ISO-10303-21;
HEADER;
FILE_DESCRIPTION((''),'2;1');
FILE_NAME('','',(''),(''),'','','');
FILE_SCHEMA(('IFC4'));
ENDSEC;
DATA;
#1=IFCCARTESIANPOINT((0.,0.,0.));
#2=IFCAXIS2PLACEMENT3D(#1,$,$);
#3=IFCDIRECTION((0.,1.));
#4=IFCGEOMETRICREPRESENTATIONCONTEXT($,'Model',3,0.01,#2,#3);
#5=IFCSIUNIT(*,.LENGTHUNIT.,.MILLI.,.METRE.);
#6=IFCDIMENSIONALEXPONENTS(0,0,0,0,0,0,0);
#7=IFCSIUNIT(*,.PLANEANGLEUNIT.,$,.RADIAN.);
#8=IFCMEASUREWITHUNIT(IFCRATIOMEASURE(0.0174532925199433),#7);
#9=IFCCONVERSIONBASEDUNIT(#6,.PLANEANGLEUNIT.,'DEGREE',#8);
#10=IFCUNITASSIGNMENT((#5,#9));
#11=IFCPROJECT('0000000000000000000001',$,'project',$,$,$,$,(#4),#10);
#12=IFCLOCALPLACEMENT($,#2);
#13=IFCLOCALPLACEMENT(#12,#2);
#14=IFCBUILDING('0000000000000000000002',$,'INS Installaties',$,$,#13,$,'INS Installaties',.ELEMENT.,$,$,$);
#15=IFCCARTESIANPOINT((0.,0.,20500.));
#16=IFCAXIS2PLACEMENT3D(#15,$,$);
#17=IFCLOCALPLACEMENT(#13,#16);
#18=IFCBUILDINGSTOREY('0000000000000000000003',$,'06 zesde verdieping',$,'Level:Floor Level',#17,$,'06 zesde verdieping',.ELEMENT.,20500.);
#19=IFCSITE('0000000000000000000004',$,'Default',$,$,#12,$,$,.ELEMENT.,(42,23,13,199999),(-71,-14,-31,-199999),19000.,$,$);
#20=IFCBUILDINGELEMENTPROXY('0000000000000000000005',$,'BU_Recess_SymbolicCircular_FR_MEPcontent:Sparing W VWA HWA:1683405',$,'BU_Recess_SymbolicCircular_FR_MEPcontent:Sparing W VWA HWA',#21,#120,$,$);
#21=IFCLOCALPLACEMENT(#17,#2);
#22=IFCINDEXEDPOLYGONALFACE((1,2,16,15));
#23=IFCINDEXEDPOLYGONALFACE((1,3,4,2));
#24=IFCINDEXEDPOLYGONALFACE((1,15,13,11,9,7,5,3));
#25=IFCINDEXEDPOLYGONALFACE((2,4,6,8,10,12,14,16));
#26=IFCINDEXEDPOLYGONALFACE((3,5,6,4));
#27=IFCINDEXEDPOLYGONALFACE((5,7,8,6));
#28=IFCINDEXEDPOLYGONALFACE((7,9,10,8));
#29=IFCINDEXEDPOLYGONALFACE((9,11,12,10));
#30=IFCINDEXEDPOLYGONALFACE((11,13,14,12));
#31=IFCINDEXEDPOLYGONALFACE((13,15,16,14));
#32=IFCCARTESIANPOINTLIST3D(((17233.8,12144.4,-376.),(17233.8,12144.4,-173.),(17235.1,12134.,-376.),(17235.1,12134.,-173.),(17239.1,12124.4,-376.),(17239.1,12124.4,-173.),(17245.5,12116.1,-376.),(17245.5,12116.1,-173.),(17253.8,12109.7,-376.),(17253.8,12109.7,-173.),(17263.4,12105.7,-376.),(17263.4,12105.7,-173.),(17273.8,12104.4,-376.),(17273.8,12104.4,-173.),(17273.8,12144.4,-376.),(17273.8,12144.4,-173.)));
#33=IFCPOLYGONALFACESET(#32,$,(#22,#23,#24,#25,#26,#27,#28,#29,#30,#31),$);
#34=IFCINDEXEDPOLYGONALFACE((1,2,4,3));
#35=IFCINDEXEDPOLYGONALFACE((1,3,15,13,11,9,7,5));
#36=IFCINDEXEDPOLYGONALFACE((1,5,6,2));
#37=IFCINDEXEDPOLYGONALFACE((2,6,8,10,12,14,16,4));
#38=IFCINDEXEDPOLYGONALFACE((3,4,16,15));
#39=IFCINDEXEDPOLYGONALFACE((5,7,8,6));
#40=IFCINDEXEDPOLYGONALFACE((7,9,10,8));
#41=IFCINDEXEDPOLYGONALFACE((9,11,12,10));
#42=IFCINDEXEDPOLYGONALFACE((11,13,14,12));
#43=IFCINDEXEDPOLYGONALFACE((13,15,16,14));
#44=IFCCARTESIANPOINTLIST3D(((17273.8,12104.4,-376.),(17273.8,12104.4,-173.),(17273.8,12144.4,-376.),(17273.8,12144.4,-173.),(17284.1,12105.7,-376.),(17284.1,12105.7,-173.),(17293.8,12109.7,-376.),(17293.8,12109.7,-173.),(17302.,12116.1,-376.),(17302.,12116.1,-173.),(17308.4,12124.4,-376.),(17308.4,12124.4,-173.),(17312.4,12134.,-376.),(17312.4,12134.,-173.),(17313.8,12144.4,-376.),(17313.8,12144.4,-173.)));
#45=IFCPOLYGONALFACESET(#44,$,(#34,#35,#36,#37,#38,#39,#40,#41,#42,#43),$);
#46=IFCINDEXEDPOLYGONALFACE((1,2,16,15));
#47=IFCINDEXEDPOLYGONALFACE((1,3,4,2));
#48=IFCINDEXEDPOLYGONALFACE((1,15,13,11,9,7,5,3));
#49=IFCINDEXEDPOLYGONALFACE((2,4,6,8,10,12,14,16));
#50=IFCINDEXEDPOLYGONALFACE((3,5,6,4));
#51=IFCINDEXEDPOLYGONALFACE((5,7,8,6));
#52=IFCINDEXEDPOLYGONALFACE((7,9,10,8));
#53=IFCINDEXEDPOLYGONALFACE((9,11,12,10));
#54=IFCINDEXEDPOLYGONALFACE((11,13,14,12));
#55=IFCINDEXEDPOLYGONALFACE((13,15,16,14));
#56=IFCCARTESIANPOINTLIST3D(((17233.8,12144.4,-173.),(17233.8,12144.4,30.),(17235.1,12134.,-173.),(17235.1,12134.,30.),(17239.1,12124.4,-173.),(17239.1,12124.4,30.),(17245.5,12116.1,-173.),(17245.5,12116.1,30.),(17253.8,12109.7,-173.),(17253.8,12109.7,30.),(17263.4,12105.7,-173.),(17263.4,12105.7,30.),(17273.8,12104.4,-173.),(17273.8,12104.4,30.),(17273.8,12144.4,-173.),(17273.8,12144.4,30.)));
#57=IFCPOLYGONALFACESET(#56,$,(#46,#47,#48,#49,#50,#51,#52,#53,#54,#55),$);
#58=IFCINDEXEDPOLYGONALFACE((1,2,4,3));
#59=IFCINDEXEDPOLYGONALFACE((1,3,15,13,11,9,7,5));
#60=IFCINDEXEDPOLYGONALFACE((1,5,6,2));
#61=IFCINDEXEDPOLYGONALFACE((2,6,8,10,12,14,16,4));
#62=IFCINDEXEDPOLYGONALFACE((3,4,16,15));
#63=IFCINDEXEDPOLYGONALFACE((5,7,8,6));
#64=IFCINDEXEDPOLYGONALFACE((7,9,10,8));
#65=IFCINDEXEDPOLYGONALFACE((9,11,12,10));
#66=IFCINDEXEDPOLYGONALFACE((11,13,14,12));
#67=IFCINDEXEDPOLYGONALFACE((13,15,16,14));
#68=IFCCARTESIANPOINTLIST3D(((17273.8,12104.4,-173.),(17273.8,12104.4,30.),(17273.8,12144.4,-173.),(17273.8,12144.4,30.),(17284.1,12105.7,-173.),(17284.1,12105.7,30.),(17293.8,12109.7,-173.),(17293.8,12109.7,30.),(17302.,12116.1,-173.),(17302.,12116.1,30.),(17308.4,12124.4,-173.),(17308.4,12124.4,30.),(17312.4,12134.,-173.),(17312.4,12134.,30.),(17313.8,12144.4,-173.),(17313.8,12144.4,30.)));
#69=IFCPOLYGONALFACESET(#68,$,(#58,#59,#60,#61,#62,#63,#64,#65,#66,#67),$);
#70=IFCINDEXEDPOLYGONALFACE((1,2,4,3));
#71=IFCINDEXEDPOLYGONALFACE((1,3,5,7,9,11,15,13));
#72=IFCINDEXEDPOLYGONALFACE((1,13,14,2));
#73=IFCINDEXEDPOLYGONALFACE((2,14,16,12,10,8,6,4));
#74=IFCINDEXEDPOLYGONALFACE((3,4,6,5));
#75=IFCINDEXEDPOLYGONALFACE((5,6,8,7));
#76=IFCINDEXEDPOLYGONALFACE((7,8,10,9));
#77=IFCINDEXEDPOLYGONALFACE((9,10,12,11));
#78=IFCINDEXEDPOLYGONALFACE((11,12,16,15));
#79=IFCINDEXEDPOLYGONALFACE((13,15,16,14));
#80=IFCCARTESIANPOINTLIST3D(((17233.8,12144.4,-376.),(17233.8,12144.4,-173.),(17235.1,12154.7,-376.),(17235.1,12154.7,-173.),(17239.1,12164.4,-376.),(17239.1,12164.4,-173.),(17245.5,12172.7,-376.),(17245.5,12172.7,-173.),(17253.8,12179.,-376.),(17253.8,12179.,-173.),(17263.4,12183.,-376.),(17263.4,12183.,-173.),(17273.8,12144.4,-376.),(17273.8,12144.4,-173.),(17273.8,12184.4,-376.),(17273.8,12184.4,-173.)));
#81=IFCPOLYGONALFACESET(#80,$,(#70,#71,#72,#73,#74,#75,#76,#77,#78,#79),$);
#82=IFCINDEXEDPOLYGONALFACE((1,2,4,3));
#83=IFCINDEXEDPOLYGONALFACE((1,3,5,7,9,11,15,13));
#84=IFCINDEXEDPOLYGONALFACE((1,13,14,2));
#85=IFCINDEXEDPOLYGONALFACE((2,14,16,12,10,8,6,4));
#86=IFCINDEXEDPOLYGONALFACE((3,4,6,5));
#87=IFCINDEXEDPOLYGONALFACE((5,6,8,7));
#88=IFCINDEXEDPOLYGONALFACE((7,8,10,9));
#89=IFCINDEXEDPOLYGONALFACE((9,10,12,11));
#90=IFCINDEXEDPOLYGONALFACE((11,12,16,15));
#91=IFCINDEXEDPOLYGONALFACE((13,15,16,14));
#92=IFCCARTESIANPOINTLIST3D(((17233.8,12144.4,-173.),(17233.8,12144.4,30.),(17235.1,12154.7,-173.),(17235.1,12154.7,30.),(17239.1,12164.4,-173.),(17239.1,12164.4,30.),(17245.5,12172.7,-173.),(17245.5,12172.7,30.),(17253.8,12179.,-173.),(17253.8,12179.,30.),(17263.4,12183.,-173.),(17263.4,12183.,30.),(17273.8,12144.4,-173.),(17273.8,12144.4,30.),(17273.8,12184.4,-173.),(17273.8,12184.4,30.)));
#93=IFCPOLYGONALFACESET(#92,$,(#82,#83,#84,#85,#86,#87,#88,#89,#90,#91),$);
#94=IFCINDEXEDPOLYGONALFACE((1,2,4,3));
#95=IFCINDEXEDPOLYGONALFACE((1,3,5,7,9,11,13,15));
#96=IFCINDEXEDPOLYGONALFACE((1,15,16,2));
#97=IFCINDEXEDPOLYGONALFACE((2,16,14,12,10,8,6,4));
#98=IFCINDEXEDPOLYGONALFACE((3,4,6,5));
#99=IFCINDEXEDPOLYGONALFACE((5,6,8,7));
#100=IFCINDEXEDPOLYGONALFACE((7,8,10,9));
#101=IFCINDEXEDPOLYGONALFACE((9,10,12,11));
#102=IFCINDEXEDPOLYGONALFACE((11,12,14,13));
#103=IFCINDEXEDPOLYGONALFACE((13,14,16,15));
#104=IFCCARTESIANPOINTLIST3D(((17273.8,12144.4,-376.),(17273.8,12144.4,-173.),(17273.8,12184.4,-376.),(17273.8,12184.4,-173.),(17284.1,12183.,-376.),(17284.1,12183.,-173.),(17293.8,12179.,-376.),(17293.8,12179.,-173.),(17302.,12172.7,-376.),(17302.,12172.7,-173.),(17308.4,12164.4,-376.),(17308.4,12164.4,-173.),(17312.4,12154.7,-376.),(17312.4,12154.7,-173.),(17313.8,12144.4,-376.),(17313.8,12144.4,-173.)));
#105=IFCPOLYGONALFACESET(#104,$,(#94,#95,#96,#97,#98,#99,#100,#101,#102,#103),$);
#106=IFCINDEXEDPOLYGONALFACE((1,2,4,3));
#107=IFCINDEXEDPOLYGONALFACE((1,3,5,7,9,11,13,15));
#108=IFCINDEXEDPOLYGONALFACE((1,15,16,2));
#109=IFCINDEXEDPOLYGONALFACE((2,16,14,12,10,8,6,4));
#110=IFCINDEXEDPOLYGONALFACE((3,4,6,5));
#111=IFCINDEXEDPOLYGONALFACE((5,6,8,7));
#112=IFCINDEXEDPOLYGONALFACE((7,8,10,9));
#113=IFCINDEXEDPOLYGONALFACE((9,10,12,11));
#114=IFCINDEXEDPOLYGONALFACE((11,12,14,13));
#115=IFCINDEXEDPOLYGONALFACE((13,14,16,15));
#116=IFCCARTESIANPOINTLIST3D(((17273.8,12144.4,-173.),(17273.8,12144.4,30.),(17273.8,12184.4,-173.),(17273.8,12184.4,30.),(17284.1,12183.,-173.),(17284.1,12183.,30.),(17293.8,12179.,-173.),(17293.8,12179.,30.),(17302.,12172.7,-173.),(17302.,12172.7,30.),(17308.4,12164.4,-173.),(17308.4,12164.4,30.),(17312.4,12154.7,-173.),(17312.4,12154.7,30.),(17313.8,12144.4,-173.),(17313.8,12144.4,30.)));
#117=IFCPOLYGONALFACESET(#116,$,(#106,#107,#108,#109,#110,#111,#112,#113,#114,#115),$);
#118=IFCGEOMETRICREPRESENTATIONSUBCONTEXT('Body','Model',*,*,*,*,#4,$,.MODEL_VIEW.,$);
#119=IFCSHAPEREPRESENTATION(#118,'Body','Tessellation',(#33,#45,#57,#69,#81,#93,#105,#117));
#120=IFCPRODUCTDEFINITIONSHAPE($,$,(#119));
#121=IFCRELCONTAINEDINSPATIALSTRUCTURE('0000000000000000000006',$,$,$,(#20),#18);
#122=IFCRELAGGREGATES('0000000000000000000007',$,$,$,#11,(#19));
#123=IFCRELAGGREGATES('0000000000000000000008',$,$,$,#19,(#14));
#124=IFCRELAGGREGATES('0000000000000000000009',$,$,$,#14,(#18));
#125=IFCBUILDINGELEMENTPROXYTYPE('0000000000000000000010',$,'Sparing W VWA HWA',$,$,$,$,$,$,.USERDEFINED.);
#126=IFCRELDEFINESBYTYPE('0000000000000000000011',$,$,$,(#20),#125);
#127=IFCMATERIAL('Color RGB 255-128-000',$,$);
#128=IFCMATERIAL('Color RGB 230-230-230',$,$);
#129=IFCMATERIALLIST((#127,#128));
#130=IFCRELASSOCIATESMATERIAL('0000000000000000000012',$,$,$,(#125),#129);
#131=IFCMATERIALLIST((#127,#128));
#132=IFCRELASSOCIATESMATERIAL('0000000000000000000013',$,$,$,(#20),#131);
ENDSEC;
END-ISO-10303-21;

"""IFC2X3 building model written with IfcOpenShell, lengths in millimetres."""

from ifc_helpers import new_model, entity, si_unit, converted_unit, direction, frame, frame_2d, origin, place, context, subcontext, project, spatial, polyline, circle_curve, parameter, trimmed, segment, composite_curve, outline, extrude, source, transform, mapped, material, material_list, type_object, type_shapes, element, save


model = new_model("IFC2X3")

# Units and contexts
model_context = context("Model", 3, precision=0.01, world=origin(), true_north=direction((0.0, 1.0)))
body_context = subcontext(model_context, "Body", "Model", "MODEL_VIEW")
ifc_project = project(units=[si_unit("LENGTHUNIT", "METRE", prefix="MILLI"), converted_unit("PLANEANGLEUNIT", "DEGREE", entity("IfcRatioMeasure", 0.0174532925199433), si_unit("PLANEANGLEUNIT", "RADIAN"), dimensions=[0, 0, 0, 0, 0, 0, 0])], contexts=[model_context])

# Site, building, storey
site_placement = place(None, origin())
site = spatial("IfcSite", under=ifc_project, at=site_placement, Name="Default", CompositionType="ELEMENT", RefLatitude=(42, 23, 13, 199999), RefLongitude=(-71, -14, -31, -199999), RefElevation=19000.0)
building_placement = place(site_placement, origin())
building = spatial("IfcBuilding", under=site, at=building_placement, Name="INS Installaties", LongName="INS Installaties", CompositionType="ELEMENT")
storey_placement = place(building_placement, frame((0.0, 0.0, 20500.0)))
storey = spatial("IfcBuildingStorey", under=building, at=storey_placement, Name="06 zesde verdieping", ObjectType="Level:Floor Level", LongName="06 zesde verdieping", CompositionType="ELEMENT", Elevation=20500.0)

# Building element proxy
ifc_material_1 = material(Name="Color RGB 255-128-000")
ifc_material_2 = material(Name="Color RGB 230-230-230")
ifc_material_list_1 = material_list([ifc_material_1, ifc_material_2])
building_element_proxy_type_1 = type_object("IfcBuildingElementProxyType", Name="Sparing W VWA HWA", PredefinedType="USERDEFINED", material=ifc_material_list_1)
shared_shape_1 = source(origin(), body_context, "Body", "SweptSolid", [
    extrude(outline(composite_curve([segment(trimmed(circle_curve(frame_2d((13.3, 13.3), x_axis=(1.0, 0.0)), 40.0), [parameter(180.0)], [parameter(270.0)], True, "PARAMETER"), True, "CONTINUOUS"), segment(polyline([(13.3, -26.7), (13.3, 13.3)]), True, "CONTINUOUS"), segment(polyline([(13.3, 13.3), (-26.7, 13.3)]), True, "CONTINUOUS")], self_intersect=False)), frame((13.3, 13.3, -403.0), z_axis=(0.0, 0.0, 1.0), x_axis=(-1.0, 0.0, 0.0)), (0.0, 0.0, 1.0), 203.0),
    extrude(outline(composite_curve([segment(polyline([(-26.7, -13.3), (13.3, -13.3)]), True, "CONTINUOUS"), segment(polyline([(13.3, -13.3), (13.3, 26.7)]), True, "CONTINUOUS"), segment(trimmed(circle_curve(frame_2d((13.3, -13.3), x_axis=(1.0, 0.0)), 40.0), [parameter(90.0)], [parameter(180.0)], True, "PARAMETER"), True, "CONTINUOUS")], self_intersect=False)), frame((-13.3, 13.3, -403.0)), (0.0, 0.0, 1.0), 203.0),
    extrude(outline(composite_curve([segment(trimmed(circle_curve(frame_2d((13.3, 13.3), x_axis=(1.0, 0.0)), 40.0), [parameter(180.0)], [parameter(270.0)], True, "PARAMETER"), True, "CONTINUOUS"), segment(polyline([(13.3, -26.7), (13.3, 13.3)]), True, "CONTINUOUS"), segment(polyline([(13.3, 13.3), (-26.7, 13.3)]), True, "CONTINUOUS")], self_intersect=False)), frame((13.3, 13.3, -200.0), z_axis=(0.0, 0.0, 1.0), x_axis=(-1.0, 0.0, 0.0)), (0.0, 0.0, 1.0), 203.0),
    extrude(outline(composite_curve([segment(polyline([(-26.7, -13.3), (13.3, -13.3)]), True, "CONTINUOUS"), segment(polyline([(13.3, -13.3), (13.3, 26.7)]), True, "CONTINUOUS"), segment(trimmed(circle_curve(frame_2d((13.3, -13.3), x_axis=(1.0, 0.0)), 40.0), [parameter(90.0)], [parameter(180.0)], True, "PARAMETER"), True, "CONTINUOUS")], self_intersect=False)), frame((-13.3, 13.3, -200.0)), (0.0, 0.0, 1.0), 203.0),
    extrude(outline(composite_curve([segment(polyline([(-26.7, -13.3), (13.3, -13.3)]), True, "CONTINUOUS"), segment(polyline([(13.3, -13.3), (13.3, 26.7)]), True, "CONTINUOUS"), segment(trimmed(circle_curve(frame_2d((13.3, -13.3), x_axis=(1.0, 0.0)), 40.0), [parameter(90.0)], [parameter(180.0)], True, "PARAMETER"), True, "CONTINUOUS")], self_intersect=False)), frame((13.3, -13.3, -403.0), z_axis=(0.0, 0.0, 1.0), x_axis=(-1.0, 0.0, 0.0)), (0.0, 0.0, 1.0), 203.0),
    extrude(outline(composite_curve([segment(polyline([(-26.7, -13.3), (13.3, -13.3)]), True, "CONTINUOUS"), segment(polyline([(13.3, -13.3), (13.3, 26.7)]), True, "CONTINUOUS"), segment(trimmed(circle_curve(frame_2d((13.3, -13.3), x_axis=(1.0, 0.0)), 40.0), [parameter(90.0)], [parameter(180.0)], True, "PARAMETER"), True, "CONTINUOUS")], self_intersect=False)), frame((13.3, -13.3, -200.0), z_axis=(0.0, 0.0, 1.0), x_axis=(-1.0, 0.0, 0.0)), (0.0, 0.0, 1.0), 203.0),
    extrude(outline(composite_curve([segment(trimmed(circle_curve(frame_2d((13.3, 13.3), x_axis=(1.0, 0.0)), 40.0), [parameter(180.0)], [parameter(270.0)], True, "PARAMETER"), True, "CONTINUOUS"), segment(polyline([(13.3, -26.7), (13.3, 13.3)]), True, "CONTINUOUS"), segment(polyline([(13.3, 13.3), (-26.7, 13.3)]), True, "CONTINUOUS")], self_intersect=False)), frame((-13.3, -13.3, -403.0)), (0.0, 0.0, 1.0), 203.0),
    extrude(outline(composite_curve([segment(trimmed(circle_curve(frame_2d((13.3, 13.3), x_axis=(1.0, 0.0)), 40.0), [parameter(180.0)], [parameter(270.0)], True, "PARAMETER"), True, "CONTINUOUS"), segment(polyline([(13.3, -26.7), (13.3, 13.3)]), True, "CONTINUOUS"), segment(polyline([(13.3, 13.3), (-26.7, 13.3)]), True, "CONTINUOUS")], self_intersect=False)), frame((-13.3, -13.3, -200.0)), (0.0, 0.0, 1.0), 203.0),
])
type_shapes(building_element_proxy_type_1, [shared_shape_1])
ifc_material_list_2 = material_list([ifc_material_1, ifc_material_2])
proxy_1_placement = place(storey_placement, frame((17273.8, 12144.4, 27.0), z_axis=(0.0, 0.0, 1.0), x_axis=(-1.0, 0.0, 0.0)))
element("IfcBuildingElementProxy", 1, at=proxy_1_placement, inside=storey, type_object=building_element_proxy_type_1, material=ifc_material_list_2, Name="BU_Recess_SymbolicCircular_FR_MEPcontent:Sparing W VWA HWA:1683405", ObjectType="BU_Recess_SymbolicCircular_FR_MEPcontent:Sparing W VWA HWA", context=body_context, shape_type="MappedRepresentation", body=[
    mapped(shared_shape_1, transform((0.0, 0.0, 0.0), scale=1.0)),
])

save(model, "model.ifc")
